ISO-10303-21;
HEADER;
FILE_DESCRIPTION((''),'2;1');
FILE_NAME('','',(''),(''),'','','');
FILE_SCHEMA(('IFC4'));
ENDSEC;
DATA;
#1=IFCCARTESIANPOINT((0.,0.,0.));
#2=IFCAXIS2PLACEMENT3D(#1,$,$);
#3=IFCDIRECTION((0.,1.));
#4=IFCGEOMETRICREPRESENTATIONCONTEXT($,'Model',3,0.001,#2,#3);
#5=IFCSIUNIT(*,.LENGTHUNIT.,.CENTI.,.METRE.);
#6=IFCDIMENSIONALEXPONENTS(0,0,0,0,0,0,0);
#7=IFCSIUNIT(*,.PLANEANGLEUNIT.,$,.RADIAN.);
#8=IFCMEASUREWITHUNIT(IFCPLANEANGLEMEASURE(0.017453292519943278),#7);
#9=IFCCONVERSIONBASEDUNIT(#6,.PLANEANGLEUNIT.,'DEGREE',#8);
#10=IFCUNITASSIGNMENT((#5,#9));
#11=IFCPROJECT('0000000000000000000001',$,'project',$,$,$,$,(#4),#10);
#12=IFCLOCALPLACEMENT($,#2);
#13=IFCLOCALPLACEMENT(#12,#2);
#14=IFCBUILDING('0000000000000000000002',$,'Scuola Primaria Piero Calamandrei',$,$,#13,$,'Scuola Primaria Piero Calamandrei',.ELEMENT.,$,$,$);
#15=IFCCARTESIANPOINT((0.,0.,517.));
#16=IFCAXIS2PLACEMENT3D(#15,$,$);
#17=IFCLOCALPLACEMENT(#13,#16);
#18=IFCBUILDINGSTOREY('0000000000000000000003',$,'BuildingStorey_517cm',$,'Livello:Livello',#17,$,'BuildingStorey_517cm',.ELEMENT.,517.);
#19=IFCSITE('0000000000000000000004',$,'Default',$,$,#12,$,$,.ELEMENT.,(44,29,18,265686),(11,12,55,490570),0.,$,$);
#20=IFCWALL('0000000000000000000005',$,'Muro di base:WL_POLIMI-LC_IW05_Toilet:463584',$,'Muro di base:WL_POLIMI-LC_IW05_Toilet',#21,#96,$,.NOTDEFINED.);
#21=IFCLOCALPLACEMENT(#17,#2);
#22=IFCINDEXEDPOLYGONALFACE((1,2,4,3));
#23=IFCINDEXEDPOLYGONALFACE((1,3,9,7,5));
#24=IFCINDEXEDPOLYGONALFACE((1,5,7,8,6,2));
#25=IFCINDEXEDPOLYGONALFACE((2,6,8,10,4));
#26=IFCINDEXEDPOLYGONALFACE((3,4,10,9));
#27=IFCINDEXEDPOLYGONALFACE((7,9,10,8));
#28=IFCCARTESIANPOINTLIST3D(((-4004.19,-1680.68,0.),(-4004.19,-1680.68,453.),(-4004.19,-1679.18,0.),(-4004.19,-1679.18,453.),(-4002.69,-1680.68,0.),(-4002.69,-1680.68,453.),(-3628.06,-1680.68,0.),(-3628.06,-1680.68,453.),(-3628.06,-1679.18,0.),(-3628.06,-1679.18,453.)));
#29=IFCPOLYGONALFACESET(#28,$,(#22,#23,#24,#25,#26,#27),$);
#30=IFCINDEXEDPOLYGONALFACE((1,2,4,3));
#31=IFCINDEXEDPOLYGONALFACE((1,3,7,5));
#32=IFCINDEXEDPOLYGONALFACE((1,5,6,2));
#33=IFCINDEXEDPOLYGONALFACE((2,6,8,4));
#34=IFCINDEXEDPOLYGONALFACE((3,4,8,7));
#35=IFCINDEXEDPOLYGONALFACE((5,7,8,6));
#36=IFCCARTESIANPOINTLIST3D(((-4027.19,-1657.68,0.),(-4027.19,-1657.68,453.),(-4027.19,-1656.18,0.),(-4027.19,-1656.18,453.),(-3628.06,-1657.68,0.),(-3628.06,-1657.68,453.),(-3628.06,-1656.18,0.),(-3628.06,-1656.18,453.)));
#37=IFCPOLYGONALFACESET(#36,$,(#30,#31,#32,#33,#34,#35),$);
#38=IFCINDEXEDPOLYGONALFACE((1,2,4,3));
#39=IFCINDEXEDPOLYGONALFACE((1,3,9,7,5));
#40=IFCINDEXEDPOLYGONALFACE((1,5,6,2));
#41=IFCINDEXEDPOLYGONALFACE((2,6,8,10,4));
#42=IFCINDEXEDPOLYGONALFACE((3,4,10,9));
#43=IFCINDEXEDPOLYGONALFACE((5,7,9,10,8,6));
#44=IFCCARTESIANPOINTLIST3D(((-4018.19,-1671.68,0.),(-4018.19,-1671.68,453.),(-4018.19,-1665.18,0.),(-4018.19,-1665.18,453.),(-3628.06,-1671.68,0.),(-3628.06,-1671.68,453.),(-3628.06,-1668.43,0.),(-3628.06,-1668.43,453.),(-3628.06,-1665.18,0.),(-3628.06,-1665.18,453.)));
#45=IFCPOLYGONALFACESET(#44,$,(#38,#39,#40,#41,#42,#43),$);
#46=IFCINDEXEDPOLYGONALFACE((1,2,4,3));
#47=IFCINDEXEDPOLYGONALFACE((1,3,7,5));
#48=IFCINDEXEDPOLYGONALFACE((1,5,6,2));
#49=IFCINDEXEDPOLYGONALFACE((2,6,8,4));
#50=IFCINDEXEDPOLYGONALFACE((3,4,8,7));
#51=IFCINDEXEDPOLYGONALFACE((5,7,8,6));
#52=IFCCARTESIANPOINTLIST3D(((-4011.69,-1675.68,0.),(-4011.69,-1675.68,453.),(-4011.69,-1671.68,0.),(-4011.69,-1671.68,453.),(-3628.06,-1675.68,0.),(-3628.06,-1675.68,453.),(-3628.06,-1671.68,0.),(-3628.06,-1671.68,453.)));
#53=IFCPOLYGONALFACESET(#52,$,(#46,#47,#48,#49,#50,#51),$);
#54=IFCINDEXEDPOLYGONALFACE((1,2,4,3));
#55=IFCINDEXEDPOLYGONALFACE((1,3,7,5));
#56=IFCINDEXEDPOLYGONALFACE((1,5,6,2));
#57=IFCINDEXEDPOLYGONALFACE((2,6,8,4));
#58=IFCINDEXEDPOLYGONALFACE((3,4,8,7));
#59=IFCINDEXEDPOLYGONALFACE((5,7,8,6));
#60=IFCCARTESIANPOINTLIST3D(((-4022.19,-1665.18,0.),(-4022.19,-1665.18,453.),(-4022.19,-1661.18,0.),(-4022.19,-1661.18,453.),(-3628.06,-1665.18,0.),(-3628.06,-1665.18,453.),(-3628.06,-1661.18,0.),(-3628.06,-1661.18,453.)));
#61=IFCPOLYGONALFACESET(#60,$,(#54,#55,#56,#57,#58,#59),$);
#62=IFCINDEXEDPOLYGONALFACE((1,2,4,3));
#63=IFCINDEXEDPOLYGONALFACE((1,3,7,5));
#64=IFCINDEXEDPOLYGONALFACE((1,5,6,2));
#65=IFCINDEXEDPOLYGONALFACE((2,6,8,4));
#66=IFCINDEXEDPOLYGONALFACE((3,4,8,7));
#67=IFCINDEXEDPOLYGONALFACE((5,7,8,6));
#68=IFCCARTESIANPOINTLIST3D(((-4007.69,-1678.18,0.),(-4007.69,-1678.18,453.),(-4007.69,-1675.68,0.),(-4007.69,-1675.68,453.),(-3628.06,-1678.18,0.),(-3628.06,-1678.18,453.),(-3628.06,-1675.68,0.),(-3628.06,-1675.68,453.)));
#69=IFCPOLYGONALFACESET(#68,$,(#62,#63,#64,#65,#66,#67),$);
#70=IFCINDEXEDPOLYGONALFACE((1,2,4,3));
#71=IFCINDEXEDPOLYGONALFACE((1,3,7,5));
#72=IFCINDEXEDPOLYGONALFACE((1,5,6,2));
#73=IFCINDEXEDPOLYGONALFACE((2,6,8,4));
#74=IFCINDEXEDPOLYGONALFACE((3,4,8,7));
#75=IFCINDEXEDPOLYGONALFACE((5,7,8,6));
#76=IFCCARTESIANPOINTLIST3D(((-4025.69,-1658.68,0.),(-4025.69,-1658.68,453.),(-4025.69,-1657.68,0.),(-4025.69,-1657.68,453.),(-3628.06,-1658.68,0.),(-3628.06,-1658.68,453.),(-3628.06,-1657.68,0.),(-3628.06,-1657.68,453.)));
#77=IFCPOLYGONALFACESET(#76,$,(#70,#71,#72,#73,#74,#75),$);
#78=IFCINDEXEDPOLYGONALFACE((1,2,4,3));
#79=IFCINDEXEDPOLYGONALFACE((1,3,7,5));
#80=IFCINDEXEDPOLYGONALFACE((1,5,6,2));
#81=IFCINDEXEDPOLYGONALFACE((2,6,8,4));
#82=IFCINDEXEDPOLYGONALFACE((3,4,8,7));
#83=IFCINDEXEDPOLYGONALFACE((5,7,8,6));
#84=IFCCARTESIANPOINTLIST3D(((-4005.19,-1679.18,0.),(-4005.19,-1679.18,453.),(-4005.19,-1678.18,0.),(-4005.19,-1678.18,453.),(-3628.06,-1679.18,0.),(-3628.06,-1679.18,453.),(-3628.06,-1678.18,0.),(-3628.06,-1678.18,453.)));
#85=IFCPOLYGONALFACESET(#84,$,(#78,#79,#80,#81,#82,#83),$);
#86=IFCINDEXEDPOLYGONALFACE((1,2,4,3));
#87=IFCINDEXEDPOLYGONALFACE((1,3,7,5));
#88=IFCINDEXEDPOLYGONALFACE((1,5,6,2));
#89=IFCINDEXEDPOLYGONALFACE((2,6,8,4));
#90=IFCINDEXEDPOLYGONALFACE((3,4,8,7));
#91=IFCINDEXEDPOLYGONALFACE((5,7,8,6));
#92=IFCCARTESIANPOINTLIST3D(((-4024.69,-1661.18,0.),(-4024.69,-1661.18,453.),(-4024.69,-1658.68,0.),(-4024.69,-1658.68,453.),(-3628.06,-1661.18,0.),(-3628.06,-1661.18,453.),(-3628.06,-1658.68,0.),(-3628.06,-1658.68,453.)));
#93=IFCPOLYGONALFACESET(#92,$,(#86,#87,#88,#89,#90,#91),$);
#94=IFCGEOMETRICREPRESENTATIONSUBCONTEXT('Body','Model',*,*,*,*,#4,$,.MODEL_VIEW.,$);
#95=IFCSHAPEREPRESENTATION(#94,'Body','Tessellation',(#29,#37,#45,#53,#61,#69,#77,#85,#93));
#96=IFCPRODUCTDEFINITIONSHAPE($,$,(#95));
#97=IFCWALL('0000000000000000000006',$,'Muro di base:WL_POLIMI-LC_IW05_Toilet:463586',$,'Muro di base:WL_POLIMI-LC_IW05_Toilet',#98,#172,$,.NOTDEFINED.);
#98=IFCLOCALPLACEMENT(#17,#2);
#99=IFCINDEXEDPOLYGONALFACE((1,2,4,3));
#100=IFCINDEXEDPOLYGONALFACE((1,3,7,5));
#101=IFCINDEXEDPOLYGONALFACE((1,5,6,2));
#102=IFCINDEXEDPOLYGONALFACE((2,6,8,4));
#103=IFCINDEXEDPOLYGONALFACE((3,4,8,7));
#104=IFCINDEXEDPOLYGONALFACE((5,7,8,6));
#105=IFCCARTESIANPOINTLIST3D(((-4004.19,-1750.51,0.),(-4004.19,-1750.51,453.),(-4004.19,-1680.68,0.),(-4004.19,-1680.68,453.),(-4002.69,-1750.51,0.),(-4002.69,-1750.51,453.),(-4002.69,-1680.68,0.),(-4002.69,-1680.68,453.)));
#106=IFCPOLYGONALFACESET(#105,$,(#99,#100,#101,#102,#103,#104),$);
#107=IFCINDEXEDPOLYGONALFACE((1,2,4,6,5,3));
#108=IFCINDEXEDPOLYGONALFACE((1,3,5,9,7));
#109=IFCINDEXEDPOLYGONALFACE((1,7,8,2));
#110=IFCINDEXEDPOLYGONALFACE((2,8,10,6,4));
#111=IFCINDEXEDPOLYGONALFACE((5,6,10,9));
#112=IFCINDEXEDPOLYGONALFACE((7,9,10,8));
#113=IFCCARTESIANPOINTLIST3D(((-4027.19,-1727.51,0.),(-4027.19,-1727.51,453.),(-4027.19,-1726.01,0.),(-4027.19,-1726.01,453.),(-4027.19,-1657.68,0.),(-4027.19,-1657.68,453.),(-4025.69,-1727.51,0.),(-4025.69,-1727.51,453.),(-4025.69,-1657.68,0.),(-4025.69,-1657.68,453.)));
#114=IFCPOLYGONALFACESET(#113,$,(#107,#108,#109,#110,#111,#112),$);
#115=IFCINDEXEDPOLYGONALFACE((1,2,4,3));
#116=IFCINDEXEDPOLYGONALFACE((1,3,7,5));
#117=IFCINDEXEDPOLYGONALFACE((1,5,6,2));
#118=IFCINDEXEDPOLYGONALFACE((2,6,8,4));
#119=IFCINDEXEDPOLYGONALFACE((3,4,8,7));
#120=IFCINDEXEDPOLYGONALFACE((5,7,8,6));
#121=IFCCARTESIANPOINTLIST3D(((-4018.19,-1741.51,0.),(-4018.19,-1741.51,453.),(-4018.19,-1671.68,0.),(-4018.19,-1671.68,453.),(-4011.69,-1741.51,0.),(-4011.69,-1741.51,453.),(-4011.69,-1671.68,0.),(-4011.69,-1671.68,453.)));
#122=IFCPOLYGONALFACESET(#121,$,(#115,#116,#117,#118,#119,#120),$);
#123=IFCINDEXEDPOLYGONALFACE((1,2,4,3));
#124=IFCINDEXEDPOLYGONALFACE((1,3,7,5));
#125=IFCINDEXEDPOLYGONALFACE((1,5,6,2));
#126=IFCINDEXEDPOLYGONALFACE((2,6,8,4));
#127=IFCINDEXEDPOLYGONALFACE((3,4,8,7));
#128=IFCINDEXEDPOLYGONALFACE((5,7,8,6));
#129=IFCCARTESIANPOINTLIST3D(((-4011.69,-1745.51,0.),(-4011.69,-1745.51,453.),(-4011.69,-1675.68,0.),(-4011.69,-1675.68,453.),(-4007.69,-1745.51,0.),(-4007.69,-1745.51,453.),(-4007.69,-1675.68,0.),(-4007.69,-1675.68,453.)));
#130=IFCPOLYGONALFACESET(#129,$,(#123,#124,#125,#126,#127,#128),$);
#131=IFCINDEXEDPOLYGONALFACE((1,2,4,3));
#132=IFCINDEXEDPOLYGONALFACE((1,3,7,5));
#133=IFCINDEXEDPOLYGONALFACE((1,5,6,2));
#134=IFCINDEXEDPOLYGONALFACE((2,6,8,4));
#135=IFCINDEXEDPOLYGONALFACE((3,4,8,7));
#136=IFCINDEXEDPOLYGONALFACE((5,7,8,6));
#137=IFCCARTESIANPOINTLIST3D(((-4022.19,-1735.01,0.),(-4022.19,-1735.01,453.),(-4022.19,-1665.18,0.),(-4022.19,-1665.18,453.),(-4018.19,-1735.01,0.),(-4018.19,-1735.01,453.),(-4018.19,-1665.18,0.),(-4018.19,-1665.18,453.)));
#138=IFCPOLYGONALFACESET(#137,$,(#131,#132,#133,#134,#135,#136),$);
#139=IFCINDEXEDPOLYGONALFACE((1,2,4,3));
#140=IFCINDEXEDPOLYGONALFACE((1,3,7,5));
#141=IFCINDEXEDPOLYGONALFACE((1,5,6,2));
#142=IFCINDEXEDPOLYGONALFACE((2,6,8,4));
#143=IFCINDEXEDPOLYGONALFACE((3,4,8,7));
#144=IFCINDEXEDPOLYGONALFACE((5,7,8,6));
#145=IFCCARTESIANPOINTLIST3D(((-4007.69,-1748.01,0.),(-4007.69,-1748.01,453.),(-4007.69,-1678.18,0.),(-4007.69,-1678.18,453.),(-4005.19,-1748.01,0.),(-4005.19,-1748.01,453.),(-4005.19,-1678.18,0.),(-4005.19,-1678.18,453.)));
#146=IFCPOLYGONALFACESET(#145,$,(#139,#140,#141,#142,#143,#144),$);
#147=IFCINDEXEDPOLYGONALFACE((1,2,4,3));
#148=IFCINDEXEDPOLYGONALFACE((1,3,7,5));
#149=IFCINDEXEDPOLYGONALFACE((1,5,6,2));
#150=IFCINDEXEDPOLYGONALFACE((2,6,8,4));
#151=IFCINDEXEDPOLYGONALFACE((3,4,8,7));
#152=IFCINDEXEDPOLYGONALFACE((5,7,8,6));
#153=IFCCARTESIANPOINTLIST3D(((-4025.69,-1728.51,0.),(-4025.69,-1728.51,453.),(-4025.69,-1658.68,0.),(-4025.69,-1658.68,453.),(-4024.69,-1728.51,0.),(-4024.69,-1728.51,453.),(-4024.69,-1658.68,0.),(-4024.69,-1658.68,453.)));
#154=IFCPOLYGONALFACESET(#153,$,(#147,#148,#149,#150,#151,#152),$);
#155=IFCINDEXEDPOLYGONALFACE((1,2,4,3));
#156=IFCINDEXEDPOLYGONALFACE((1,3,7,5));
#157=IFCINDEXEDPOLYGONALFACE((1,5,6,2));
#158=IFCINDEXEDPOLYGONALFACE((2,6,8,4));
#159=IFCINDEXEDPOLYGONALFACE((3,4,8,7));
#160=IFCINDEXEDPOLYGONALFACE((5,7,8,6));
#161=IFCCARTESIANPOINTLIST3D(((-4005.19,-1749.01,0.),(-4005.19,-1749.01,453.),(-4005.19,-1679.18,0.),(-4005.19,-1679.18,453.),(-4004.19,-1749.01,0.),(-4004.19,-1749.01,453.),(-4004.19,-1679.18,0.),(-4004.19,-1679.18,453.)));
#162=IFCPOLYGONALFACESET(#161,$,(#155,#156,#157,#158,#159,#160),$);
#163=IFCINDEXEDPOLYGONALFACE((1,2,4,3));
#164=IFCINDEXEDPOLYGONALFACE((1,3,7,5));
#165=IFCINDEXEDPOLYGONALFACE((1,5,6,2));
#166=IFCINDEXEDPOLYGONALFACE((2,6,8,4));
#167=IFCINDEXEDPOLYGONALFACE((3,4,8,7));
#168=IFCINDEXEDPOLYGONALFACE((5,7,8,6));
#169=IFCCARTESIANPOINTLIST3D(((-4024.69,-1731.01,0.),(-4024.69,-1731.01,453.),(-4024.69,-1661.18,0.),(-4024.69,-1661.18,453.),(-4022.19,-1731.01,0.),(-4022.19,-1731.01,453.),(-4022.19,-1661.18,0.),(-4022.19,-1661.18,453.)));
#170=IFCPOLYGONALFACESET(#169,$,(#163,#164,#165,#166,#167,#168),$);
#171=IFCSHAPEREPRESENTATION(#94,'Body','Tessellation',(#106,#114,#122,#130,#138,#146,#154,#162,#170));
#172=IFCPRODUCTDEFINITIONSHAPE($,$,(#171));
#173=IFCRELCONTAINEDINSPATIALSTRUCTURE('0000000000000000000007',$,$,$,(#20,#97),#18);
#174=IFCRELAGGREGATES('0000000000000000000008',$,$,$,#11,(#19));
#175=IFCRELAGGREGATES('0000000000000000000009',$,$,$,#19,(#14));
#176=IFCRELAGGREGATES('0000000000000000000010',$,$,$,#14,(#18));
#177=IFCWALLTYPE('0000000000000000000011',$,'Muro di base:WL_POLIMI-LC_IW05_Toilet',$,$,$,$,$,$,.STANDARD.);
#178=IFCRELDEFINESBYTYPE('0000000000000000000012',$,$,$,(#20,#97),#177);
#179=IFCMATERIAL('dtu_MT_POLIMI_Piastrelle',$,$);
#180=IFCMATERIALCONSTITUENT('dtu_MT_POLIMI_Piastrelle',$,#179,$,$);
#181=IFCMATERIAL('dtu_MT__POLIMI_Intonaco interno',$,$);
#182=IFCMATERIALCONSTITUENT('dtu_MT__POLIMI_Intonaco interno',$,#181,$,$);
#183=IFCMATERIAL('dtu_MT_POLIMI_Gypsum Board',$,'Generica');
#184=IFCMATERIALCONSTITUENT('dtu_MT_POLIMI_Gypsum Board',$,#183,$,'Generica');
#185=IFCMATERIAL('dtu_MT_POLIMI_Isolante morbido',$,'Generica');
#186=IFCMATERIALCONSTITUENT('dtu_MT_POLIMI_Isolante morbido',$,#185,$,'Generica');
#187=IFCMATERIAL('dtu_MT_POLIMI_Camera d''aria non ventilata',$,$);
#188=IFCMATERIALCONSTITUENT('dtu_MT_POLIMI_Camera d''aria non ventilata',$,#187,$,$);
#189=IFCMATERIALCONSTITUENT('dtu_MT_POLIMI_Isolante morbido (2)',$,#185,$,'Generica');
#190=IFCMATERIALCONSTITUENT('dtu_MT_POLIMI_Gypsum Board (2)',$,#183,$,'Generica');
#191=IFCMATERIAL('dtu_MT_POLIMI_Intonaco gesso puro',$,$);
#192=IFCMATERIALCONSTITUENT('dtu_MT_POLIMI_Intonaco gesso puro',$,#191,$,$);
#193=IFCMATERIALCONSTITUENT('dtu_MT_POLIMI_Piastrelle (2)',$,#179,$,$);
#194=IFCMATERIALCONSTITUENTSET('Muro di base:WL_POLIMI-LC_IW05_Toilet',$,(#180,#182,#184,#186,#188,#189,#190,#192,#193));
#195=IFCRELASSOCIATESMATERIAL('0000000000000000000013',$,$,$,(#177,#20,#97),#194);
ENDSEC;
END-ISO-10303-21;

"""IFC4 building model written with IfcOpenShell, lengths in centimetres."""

from ifc_helpers import new_model, entity, si_unit, converted_unit, direction, frame, origin, place, context, subcontext, project, spatial, indexed_curve, outline, extrude, material, constituent, constituent_set, type_object, element, save


model = new_model("IFC4")

# Units and contexts
model_context = context("Model", 3, precision=0.001, world=origin(), true_north=direction((0.0, 1.0)))
body_context = subcontext(model_context, "Body", "Model", "MODEL_VIEW")
ifc_project = project(units=[si_unit("LENGTHUNIT", "METRE", prefix="CENTI"), converted_unit("PLANEANGLEUNIT", "DEGREE", entity("IfcPlaneAngleMeasure", 0.017453292519943278), si_unit("PLANEANGLEUNIT", "RADIAN"), dimensions=[0, 0, 0, 0, 0, 0, 0])], contexts=[model_context])

# Site, building, storey
site_placement = place(None, origin())
site = spatial("IfcSite", under=ifc_project, at=site_placement, Name="Default", CompositionType="ELEMENT", RefLatitude=(44, 29, 18, 265686), RefLongitude=(11, 12, 55, 490570), RefElevation=0.0)
building_placement = place(site_placement, origin())
building = spatial("IfcBuilding", under=site, at=building_placement, Name="Scuola Primaria Piero Calamandrei", LongName="Scuola Primaria Piero Calamandrei", CompositionType="ELEMENT")
storey_placement = place(building_placement, frame((0.0, 0.0, 517.0)))
storey = spatial("IfcBuildingStorey", under=building, at=storey_placement, Name="BuildingStorey_517cm", ObjectType="Livello:Livello", LongName="BuildingStorey_517cm", CompositionType="ELEMENT", Elevation=517.0)

# Shared definitions
ifc_material_1 = material(Name="dtu_MT_POLIMI_Isolante morbido", Category="Generica")
ifc_material_2 = material(Name="dtu_MT_POLIMI_Gypsum Board", Category="Generica")
ifc_material_3 = material(Name="dtu_MT__POLIMI_Intonaco interno")

# Shared definitions
ifc_material_4 = material(Name="dtu_MT_POLIMI_Camera d'aria non ventilata")
ifc_material_5 = material(Name="dtu_MT_POLIMI_Intonaco gesso puro")
ifc_material_6 = material(Name="dtu_MT_POLIMI_Piastrelle")

# Walls
ifc_constituent_1 = constituent(ifc_material_6, Name="dtu_MT_POLIMI_Piastrelle")
ifc_constituent_2 = constituent(ifc_material_3, Name="dtu_MT__POLIMI_Intonaco interno")
ifc_constituent_3 = constituent(ifc_material_2, Name="dtu_MT_POLIMI_Gypsum Board", Category="Generica")
ifc_constituent_4 = constituent(ifc_material_1, Name="dtu_MT_POLIMI_Isolante morbido", Category="Generica")
ifc_constituent_5 = constituent(ifc_material_4, Name="dtu_MT_POLIMI_Camera d'aria non ventilata")
ifc_constituent_6 = constituent(ifc_material_1, Name="dtu_MT_POLIMI_Isolante morbido (2)", Category="Generica")
ifc_constituent_7 = constituent(ifc_material_2, Name="dtu_MT_POLIMI_Gypsum Board (2)", Category="Generica")
ifc_constituent_8 = constituent(ifc_material_5, Name="dtu_MT_POLIMI_Intonaco gesso puro")
ifc_constituent_9 = constituent(ifc_material_6, Name="dtu_MT_POLIMI_Piastrelle (2)")
ifc_constituent_set_1 = constituent_set(constituents=[ifc_constituent_1, ifc_constituent_2, ifc_constituent_3, ifc_constituent_4, ifc_constituent_5, ifc_constituent_6, ifc_constituent_7, ifc_constituent_8, ifc_constituent_9], Name="Muro di base:WL_POLIMI-LC_IW05_Toilet")
wall_type_1 = type_object("IfcWallType", Name="Muro di base:WL_POLIMI-LC_IW05_Toilet", PredefinedType="STANDARD", material=ifc_constituent_set_1)
wall_1_placement = place(storey_placement, frame((-3628.06, -1668.43, 0.0), z_axis=(0.0, 0.0, 1.0), x_axis=(-1.0, 0.0, 0.0)))
element("IfcWall", 1, at=wall_1_placement, inside=storey, type_object=wall_type_1, material=ifc_constituent_set_1, Name="Muro di base:WL_POLIMI-LC_IW05_Toilet:463584", ObjectType="Muro di base:WL_POLIMI-LC_IW05_Toilet", PredefinedType="NOTDEFINED", context=body_context, shape_type="SweptSolid", body=[
    extrude(outline(indexed_curve([(-149.25, -0.6), (225.38, -0.6), (225.38, 0.9), (-150.75, 0.9), (-150.75, -0.6), (-149.25, -0.6)], self_intersect=False)), frame((225.38, 11.65, 0.0), z_axis=(0.0, 0.0, 1.0), x_axis=(-1.0, 0.0, 0.0)), (0.0, 0.0, 1.0), 453.0),
    extrude(outline(indexed_curve([(-0.75, -199.57), (0.75, -199.57), (0.75, 199.57), (-0.75, 199.57), (-0.75, -199.57)], self_intersect=False)), frame((199.57, -11.5, 0.0), z_axis=(0.0, 0.0, 1.0), x_axis=(0.0, 1.0, 0.0)), (0.0, 0.0, 1.0), 453.0),
    extrude(outline(indexed_curve([(-156.05, -3.25), (234.08, -3.25), (234.08, 3.25), (-156.05, 3.25), (-156.05, 0.0), (-156.05, -3.25)], self_intersect=False)), frame((156.05, 0.0, 0.0)), (0.0, 0.0, 1.0), 453.0),
    extrude(outline(indexed_curve([(-191.82, -2.0), (191.82, -2.0), (191.82, 2.0), (-191.82, 2.0), (-191.82, -2.0)], self_intersect=False)), frame((191.82, 5.25, 0.0)), (0.0, 0.0, 1.0), 453.0),
    extrude(outline(indexed_curve([(-197.07, -2.0), (197.07, -2.0), (197.07, 2.0), (-197.07, 2.0), (-197.07, -2.0)], self_intersect=False)), frame((197.07, -5.25, 0.0)), (0.0, 0.0, 1.0), 453.0),
    extrude(outline(indexed_curve([(-189.82, -1.25), (189.82, -1.25), (189.82, 1.25), (-189.82, 1.25), (-189.82, -1.25)], self_intersect=False)), frame((189.82, 8.5, 0.0)), (0.0, 0.0, 1.0), 453.0),
    extrude(outline(indexed_curve([(-198.82, -0.5), (198.82, -0.5), (198.82, 0.5), (-198.82, 0.5), (-198.82, -0.5)], self_intersect=False)), frame((198.82, -10.25, 0.0)), (0.0, 0.0, 1.0), 453.0),
    extrude(outline(indexed_curve([(-188.57, -0.5), (188.57, -0.5), (188.57, 0.5), (-188.57, 0.5), (-188.57, -0.5)], self_intersect=False)), frame((188.57, 10.25, 0.0)), (0.0, 0.0, 1.0), 453.0),
    extrude(outline(indexed_curve([(-198.32, -1.25), (198.32, -1.25), (198.32, 1.25), (-198.32, 1.25), (-198.32, -1.25)], self_intersect=False)), frame((198.32, -8.5, 0.0)), (0.0, 0.0, 1.0), 453.0),
])
wall_2_placement = place(storey_placement, frame((-4014.94, -1680.68, 0.0), z_axis=(0.0, 0.0, 1.0), x_axis=(0.0, -1.0, 0.0)))
element("IfcWall", 2, at=wall_2_placement, inside=storey, type_object=wall_type_1, material=ifc_constituent_set_1, Name="Muro di base:WL_POLIMI-LC_IW05_Toilet:463586", ObjectType="Muro di base:WL_POLIMI-LC_IW05_Toilet", PredefinedType="NOTDEFINED", context=body_context, shape_type="SweptSolid", body=[
    extrude(outline(indexed_curve([(-0.75, -34.91), (0.75, -34.91), (0.75, 34.91), (-0.75, 34.91), (-0.75, -34.91)], self_intersect=False)), frame((34.91, 11.5, 0.0), z_axis=(0.0, 0.0, 1.0), x_axis=(0.0, -1.0, 0.0)), (0.0, 0.0, 1.0), 453.0),
    extrude(outline(indexed_curve([(26.73, -0.6), (28.23, -0.6), (28.23, 0.9), (-41.6, 0.9), (-41.6, -0.6), (26.73, -0.6)], self_intersect=False)), frame((18.6, -11.65, 0.0)), (0.0, 0.0, 1.0), 453.0),
    extrude(outline(indexed_curve([(-34.91, -3.25), (34.91, -3.25), (34.91, 3.25), (-34.91, 3.25), (-34.91, -3.25)], self_intersect=False)), frame((25.91, 0.0, 0.0)), (0.0, 0.0, 1.0), 453.0),
    extrude(outline(indexed_curve([(-34.91, -2.0), (34.91, -2.0), (34.91, 2.0), (-34.91, 2.0), (-34.91, -2.0)], self_intersect=False)), frame((29.91, 5.25, 0.0)), (0.0, 0.0, 1.0), 453.0),
    extrude(outline(indexed_curve([(-34.91, -2.0), (34.91, -2.0), (34.91, 2.0), (-34.91, 2.0), (-34.91, -2.0)], self_intersect=False)), frame((19.41, -5.25, 0.0)), (0.0, 0.0, 1.0), 453.0),
    extrude(outline(indexed_curve([(-34.91, -1.25), (34.91, -1.25), (34.91, 1.25), (-34.91, 1.25), (-34.91, -1.25)], self_intersect=False)), frame((32.41, 8.5, 0.0)), (0.0, 0.0, 1.0), 453.0),
    extrude(outline(indexed_curve([(-34.91, -0.5), (34.91, -0.5), (34.91, 0.5), (-34.91, 0.5), (-34.91, -0.5)], self_intersect=False)), frame((12.91, -10.25, 0.0)), (0.0, 0.0, 1.0), 453.0),
    extrude(outline(indexed_curve([(-34.91, -0.5), (34.91, -0.5), (34.91, 0.5), (-34.91, 0.5), (-34.91, -0.5)], self_intersect=False)), frame((33.41, 10.25, 0.0)), (0.0, 0.0, 1.0), 453.0),
    extrude(outline(indexed_curve([(-34.91, -1.25), (34.91, -1.25), (34.91, 1.25), (-34.91, 1.25), (-34.91, -1.25)], self_intersect=False)), frame((15.41, -8.5, 0.0)), (0.0, 0.0, 1.0), 453.0),
])

save(model, "model.ifc")
